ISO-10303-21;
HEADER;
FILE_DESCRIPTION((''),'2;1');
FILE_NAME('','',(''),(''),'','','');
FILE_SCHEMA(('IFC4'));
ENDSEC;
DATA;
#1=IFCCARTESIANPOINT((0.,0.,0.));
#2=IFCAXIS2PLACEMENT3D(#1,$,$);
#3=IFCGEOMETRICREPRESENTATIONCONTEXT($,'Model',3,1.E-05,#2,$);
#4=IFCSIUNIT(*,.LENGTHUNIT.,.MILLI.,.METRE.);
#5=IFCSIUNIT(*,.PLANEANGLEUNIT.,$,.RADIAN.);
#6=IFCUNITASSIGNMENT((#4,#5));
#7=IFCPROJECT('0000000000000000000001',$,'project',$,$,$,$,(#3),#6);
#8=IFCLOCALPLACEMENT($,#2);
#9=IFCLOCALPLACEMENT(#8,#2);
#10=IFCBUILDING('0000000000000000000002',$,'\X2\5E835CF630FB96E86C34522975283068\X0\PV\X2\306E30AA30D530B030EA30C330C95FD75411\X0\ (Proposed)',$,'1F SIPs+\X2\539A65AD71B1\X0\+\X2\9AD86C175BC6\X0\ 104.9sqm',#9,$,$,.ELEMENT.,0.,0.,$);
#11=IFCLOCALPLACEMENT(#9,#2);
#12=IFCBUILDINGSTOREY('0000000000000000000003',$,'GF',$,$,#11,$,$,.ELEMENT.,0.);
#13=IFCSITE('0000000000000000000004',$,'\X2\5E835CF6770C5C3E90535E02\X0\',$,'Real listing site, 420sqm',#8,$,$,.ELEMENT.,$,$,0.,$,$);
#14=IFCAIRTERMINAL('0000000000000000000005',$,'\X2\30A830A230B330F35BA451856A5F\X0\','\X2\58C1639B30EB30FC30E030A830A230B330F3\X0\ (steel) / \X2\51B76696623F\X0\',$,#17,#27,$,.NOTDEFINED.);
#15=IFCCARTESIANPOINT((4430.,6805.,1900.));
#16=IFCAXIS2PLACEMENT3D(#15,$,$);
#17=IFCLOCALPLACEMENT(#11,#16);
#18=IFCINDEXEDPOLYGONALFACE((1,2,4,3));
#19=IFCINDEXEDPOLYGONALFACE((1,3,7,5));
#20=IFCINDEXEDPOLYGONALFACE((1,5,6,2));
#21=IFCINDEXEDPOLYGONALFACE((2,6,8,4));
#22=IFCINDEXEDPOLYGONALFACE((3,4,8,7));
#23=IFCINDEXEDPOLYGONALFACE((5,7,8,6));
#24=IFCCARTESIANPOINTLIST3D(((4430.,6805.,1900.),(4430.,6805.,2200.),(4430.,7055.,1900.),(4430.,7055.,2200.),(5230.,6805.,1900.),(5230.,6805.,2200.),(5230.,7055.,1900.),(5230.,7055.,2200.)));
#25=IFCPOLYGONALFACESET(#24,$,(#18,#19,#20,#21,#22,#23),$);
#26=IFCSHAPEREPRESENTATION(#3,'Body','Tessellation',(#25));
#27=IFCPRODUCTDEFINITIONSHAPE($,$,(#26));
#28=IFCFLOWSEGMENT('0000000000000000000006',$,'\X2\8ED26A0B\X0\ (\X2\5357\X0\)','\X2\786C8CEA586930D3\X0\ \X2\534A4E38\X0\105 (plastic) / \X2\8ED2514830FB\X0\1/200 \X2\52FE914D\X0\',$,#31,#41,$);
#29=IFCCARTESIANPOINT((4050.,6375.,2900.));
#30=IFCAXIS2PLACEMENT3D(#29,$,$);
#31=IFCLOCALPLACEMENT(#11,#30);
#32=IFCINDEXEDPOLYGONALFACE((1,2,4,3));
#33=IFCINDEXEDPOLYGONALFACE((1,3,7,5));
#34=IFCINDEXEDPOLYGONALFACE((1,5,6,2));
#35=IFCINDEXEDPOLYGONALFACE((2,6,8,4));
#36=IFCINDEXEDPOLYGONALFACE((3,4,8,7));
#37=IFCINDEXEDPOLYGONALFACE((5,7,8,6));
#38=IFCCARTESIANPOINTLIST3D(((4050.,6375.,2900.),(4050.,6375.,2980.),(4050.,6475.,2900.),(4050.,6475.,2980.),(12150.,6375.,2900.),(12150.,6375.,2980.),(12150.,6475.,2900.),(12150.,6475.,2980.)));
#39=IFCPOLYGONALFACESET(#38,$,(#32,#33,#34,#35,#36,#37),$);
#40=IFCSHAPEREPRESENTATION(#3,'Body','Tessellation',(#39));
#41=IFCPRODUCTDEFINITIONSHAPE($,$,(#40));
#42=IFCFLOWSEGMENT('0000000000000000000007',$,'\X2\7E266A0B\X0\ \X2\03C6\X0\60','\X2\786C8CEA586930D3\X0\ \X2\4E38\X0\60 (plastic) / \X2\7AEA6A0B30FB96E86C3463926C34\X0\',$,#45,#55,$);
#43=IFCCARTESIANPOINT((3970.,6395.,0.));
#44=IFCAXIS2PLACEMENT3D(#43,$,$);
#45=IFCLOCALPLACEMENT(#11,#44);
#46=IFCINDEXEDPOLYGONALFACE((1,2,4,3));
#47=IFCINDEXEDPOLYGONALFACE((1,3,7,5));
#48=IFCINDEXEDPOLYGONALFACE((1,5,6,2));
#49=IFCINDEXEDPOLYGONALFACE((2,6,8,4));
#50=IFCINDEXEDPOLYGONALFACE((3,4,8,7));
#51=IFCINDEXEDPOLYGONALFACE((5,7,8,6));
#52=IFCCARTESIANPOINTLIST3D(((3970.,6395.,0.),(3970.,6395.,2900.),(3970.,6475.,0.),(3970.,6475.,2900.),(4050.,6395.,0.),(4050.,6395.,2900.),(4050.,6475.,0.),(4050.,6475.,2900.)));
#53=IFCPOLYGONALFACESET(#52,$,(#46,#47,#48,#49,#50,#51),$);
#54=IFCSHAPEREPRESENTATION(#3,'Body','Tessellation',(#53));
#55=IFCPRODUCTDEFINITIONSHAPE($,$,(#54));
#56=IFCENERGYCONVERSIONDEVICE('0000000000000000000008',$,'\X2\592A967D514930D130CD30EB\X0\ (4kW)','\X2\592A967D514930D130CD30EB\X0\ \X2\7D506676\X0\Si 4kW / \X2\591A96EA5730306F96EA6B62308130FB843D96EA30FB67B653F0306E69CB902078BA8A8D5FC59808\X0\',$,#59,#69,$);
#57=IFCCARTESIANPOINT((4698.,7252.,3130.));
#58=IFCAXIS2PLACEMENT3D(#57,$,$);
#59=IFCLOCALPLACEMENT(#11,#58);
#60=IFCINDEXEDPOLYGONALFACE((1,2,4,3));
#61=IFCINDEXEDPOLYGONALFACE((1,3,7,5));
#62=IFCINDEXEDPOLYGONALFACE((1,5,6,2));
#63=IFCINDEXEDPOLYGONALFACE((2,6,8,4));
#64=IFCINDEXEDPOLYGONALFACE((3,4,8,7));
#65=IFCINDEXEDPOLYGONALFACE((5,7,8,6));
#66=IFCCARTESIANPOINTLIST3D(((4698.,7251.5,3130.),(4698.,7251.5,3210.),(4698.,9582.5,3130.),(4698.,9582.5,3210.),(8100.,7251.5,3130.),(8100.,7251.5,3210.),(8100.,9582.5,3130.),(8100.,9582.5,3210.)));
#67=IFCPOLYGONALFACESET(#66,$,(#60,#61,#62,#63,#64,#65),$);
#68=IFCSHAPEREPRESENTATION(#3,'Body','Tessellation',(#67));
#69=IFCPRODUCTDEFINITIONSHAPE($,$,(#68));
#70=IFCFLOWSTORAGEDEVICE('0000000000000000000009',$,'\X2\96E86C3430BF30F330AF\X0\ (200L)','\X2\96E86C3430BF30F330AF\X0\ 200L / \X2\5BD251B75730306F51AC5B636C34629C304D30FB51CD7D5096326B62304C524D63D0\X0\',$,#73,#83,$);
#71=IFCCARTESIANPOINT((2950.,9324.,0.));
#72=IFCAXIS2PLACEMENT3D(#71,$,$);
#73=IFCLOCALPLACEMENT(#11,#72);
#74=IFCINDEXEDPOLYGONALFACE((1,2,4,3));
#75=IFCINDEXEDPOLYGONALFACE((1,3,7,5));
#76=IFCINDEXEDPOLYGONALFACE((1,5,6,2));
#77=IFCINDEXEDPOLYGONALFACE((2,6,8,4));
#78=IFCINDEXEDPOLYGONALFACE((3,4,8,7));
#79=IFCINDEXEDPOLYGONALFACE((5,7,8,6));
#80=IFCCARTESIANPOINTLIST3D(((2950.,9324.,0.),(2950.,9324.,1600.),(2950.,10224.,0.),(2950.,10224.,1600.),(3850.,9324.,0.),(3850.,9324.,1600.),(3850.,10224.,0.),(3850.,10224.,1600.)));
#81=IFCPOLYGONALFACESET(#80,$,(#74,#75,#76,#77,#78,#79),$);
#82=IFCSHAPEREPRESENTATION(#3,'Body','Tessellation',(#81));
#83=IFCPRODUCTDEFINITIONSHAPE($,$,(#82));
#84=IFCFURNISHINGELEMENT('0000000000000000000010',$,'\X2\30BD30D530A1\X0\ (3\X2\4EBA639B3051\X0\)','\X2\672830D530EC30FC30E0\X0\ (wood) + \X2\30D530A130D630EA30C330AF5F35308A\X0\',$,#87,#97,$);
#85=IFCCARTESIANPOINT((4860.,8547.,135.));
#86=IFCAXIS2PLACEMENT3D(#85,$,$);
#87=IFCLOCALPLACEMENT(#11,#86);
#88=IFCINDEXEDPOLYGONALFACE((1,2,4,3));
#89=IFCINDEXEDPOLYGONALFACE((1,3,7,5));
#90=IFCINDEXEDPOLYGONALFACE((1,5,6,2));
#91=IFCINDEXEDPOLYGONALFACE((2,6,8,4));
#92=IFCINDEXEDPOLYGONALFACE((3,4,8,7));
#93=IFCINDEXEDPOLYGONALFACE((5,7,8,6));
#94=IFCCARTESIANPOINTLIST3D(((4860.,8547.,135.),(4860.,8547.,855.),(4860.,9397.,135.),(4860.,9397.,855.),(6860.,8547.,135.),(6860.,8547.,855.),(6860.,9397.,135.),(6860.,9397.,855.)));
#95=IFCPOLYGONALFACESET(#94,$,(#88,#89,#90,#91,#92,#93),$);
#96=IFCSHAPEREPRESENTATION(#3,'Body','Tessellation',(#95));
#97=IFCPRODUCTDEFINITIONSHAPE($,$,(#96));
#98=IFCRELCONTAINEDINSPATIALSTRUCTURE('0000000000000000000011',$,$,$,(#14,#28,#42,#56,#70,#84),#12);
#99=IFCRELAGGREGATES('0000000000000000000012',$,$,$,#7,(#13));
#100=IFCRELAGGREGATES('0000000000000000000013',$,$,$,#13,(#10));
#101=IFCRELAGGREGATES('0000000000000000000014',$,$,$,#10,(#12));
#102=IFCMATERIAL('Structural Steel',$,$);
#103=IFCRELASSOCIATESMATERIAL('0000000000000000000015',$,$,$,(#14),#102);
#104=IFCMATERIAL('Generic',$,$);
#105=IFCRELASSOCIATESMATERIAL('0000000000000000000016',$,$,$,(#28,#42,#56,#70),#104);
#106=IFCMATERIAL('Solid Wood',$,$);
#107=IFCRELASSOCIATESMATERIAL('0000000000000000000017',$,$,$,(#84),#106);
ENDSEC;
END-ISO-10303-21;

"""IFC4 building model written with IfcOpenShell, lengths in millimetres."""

from ifc_helpers import new_model, si_unit, frame, frame_2d, origin, place, context, project, spatial, rectangle, extrude, material, element, save


model = new_model("IFC4")

# Units and contexts
model_context = context("Model", 3, precision=1e-05, world=origin())
ifc_project = project(units=[si_unit("LENGTHUNIT", "METRE", prefix="MILLI"), si_unit("PLANEANGLEUNIT", "RADIAN")], contexts=[model_context])

# Site, building, storey
site_placement = place(None, origin())
site = spatial("IfcSite", under=ifc_project, at=site_placement, Name="広島県尾道市", ObjectType="Real listing site, 420sqm", CompositionType="ELEMENT", RefElevation=0.0)
building_placement = place(site_placement, origin())
building = spatial("IfcBuilding", under=site, at=building_placement, Name="広島・雨水利用とPVのオフグリッド志向 (Proposed)", ObjectType="1F SIPs+厚断熱+高気密 104.9sqm", CompositionType="ELEMENT", ElevationOfRefHeight=0.0, ElevationOfTerrain=0.0)
storey_placement = place(building_placement, origin())
storey = spatial("IfcBuildingStorey", under=building, at=storey_placement, Name="GF", CompositionType="ELEMENT", Elevation=0.0)

# Shared definitions
ifc_material_1 = material(Name="Solid Wood")

# Shared definitions
ifc_material_2 = material(Name="Structural Steel")

# Shared definitions
ifc_material_3 = material(Name="Generic")

# Air terminal
air_terminal_placement = place(storey_placement, frame((4430.0, 6805.0, 1900.0)))
element("IfcAirTerminal", 1, at=air_terminal_placement, inside=storey, material=ifc_material_2, Name="エアコン室内機", Description="壁掛ルームエアコン (steel) / 冷暖房", PredefinedType="NOTDEFINED", context=model_context, shape_type="SweptSolid", body=[
    extrude(rectangle(XDim=800.0, YDim=250.0, at=frame_2d((400.0, 125.0))), frame((4430.0, 6805.0, 1900.0)), (0.0, 0.0, 1.0), 300.0),
])

# Flow segments
flow_segment_1_placement = place(storey_placement, frame((4050.0, 6375.0, 2900.0)))
element("IfcFlowSegment", 2, at=flow_segment_1_placement, inside=storey, material=ifc_material_3, Name="軒樋 (南)", Description="硬質塩ビ 半丸105 (plastic) / 軒先・1/200 勾配", context=model_context, shape_type="SweptSolid", body=[
    extrude(rectangle(XDim=8100.0, YDim=100.0, at=frame_2d((4050.0, 50.0))), frame((4050.0, 6375.0, 2900.0)), (0.0, 0.0, 1.0), 80.0),
])
flow_segment_2_placement = place(storey_placement, frame((3970.0, 6395.0, 0.0)))
element("IfcFlowSegment", 3, at=flow_segment_2_placement, inside=storey, material=ifc_material_3, Name="縦樋 φ60", Description="硬質塩ビ 丸60 (plastic) / 竪樋・雨水排水", context=model_context, shape_type="SweptSolid", body=[
    extrude(rectangle(XDim=80.0, YDim=80.0, at=frame_2d((40.0, 40.0))), frame((3970.0, 6395.0, 0.0)), (0.0, 0.0, 1.0), 2900.0),
])

# Energy conversion device
energy_conversion_device_placement = place(storey_placement, frame((4698.0, 7252.0, 3130.0)))
element("IfcEnergyConversionDevice", 4, at=energy_conversion_device_placement, inside=storey, material=ifc_material_3, Name="太陽光パネル (4kW)", Description="太陽光パネル 結晶Si 4kW / 多雪地は雪止め・落雪・架台の構造確認必須", context=model_context, shape_type="SweptSolid", body=[
    extrude(rectangle(XDim=3402.0, YDim=2331.0, at=frame_2d((1701.0, 1165.0))), frame((4698.0, 7252.0, 3130.0)), (0.0, 0.0, 1.0), 80.0),
])

# Flow storage device
flow_storage_device_placement = place(storey_placement, frame((2950.0, 9324.0, 0.0)))
element("IfcFlowStorageDevice", 5, at=flow_storage_device_placement, inside=storey, material=ifc_material_3, Name="雨水タンク (200L)", Description="雨水タンク 200L / 寒冷地は冬季水抜き・凍結防止が前提", context=model_context, shape_type="SweptSolid", body=[
    extrude(rectangle(XDim=900.0, YDim=900.0, at=frame_2d((450.0, 450.0))), frame((2950.0, 9324.0, 0.0)), (0.0, 0.0, 1.0), 1600.0),
])

# Furnishing element
furnishing_placement = place(storey_placement, frame((4860.0, 8547.0, 135.0)))
element("IfcFurnishingElement", 6, at=furnishing_placement, inside=storey, material=ifc_material_1, Name="ソファ (3人掛け)", Description="木フレーム (wood) + ファブリック張り", context=model_context, shape_type="SweptSolid", body=[
    extrude(rectangle(XDim=2000.0, YDim=850.0, at=frame_2d((1000.0, 425.0))), frame((4860.0, 8547.0, 135.0)), (0.0, 0.0, 1.0), 720.0),
])

save(model, "model.ifc")
